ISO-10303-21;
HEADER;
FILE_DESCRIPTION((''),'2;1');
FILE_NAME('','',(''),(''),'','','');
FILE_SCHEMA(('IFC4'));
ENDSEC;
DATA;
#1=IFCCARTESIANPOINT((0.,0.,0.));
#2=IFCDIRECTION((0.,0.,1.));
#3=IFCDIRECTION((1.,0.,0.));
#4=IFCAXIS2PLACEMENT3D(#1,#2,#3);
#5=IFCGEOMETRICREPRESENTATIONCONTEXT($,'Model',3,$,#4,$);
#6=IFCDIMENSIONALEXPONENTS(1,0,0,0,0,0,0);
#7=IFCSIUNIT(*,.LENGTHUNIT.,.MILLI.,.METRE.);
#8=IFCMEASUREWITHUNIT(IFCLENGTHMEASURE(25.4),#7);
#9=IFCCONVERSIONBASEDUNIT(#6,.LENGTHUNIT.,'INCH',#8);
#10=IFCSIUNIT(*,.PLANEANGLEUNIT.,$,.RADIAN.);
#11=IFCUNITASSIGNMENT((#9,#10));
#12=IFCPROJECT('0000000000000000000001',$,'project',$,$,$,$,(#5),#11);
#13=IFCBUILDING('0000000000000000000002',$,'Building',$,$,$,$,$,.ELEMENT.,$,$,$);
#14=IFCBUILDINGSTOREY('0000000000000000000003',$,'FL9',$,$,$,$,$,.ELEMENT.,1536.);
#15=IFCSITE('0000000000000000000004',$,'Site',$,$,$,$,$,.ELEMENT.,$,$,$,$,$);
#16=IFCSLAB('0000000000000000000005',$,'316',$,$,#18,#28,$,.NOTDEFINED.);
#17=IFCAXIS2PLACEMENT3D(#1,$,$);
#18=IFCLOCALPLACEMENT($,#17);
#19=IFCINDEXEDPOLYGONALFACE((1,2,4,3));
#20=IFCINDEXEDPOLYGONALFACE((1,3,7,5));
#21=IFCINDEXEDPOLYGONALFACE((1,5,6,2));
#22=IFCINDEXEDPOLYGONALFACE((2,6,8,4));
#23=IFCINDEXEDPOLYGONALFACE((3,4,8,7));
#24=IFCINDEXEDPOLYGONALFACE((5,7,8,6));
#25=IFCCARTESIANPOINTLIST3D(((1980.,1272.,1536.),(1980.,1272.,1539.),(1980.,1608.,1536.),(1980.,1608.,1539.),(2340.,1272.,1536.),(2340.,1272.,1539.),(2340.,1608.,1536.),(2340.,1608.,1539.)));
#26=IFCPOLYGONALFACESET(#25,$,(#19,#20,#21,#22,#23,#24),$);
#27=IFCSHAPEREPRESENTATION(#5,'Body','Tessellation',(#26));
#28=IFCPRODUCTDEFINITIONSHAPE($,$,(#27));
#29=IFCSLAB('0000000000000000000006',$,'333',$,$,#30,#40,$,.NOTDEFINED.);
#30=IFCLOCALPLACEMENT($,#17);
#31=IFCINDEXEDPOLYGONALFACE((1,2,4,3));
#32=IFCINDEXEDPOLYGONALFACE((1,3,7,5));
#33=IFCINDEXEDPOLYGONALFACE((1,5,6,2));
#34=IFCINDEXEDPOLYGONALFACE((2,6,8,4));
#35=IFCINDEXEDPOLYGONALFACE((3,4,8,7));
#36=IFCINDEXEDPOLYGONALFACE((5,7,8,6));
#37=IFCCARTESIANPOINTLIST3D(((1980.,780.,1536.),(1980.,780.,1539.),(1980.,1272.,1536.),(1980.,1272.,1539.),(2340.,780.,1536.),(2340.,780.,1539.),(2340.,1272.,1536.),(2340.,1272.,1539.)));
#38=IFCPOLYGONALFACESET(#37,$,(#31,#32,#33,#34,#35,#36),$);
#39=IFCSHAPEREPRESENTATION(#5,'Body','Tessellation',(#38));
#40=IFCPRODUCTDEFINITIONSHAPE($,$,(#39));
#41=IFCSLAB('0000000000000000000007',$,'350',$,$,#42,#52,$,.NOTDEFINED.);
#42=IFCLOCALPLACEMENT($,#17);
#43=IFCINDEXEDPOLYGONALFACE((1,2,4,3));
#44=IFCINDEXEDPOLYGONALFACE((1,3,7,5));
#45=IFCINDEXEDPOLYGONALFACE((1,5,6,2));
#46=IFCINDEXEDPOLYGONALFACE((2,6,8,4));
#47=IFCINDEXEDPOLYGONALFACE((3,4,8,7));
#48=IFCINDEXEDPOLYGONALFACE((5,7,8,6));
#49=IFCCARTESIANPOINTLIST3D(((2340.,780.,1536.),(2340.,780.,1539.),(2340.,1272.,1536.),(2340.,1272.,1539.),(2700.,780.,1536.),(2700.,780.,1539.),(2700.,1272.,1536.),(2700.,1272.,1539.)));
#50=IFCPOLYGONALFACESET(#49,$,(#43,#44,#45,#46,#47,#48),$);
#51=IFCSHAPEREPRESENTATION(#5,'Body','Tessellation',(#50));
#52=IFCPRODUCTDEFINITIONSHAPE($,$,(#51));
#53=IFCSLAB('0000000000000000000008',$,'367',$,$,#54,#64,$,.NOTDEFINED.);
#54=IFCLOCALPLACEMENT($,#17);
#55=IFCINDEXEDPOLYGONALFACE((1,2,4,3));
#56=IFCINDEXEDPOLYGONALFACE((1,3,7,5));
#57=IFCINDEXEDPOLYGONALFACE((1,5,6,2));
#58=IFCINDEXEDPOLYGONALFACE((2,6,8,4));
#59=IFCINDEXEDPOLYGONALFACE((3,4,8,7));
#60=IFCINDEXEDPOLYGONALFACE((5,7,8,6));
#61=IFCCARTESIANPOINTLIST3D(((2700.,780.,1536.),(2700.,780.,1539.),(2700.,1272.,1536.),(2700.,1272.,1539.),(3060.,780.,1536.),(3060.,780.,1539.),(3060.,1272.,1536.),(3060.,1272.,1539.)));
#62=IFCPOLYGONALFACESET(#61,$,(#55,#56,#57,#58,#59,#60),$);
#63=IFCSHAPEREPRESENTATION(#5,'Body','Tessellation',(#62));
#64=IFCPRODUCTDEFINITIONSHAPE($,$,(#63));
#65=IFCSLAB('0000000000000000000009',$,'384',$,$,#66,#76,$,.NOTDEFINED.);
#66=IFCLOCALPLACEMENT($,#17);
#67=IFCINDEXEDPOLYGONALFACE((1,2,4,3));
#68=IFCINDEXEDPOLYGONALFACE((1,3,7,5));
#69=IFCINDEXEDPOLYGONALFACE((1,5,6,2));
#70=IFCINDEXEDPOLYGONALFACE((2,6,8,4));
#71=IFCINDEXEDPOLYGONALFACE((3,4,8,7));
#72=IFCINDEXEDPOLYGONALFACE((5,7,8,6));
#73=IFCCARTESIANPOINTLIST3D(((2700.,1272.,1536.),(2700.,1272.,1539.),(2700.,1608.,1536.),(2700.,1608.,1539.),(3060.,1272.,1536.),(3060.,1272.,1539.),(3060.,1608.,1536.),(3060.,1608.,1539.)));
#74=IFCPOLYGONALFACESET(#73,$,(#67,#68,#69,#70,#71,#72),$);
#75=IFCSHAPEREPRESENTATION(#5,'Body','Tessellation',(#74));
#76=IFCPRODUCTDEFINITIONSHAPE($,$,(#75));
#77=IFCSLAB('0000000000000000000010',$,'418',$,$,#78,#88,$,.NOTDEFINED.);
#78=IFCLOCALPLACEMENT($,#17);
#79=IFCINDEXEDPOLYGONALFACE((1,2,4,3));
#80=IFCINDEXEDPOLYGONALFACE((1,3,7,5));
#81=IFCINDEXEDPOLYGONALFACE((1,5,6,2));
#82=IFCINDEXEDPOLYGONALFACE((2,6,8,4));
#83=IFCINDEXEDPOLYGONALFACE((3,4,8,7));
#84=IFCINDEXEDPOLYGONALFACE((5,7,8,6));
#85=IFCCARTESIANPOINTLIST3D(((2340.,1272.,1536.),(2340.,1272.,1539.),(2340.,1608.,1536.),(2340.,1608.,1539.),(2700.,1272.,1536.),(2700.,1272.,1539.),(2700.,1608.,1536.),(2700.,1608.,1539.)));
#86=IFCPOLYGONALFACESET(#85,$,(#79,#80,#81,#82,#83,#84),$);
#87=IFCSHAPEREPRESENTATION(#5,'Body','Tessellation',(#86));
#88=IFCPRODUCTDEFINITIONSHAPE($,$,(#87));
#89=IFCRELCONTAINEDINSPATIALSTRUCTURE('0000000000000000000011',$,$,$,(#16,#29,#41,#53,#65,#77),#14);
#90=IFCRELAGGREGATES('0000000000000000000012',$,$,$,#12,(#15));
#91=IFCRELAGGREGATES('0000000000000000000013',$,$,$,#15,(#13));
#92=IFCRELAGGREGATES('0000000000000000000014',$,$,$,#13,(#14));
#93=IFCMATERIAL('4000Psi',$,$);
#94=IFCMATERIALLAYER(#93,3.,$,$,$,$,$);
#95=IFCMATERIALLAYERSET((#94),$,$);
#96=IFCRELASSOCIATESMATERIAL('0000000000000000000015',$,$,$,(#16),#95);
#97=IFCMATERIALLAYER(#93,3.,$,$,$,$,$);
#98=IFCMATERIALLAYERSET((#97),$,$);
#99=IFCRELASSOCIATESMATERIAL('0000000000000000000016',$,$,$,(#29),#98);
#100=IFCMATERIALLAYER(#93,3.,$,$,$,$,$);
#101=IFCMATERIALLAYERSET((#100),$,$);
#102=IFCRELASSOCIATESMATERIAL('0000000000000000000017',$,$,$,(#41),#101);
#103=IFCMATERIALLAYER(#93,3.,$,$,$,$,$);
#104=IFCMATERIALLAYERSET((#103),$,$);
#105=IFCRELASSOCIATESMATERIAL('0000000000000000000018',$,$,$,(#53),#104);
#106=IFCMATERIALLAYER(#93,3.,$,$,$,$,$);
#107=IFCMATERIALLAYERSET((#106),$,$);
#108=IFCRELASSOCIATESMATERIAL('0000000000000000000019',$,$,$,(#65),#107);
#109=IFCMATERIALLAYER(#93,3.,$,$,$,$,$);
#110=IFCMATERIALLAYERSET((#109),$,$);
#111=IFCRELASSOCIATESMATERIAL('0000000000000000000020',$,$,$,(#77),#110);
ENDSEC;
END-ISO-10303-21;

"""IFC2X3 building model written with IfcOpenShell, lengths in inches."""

from ifc_helpers import new_model, entity, si_unit, converted_unit, frame, origin_with_axes, place, context, project, spatial, polyline, outline, extrude, material, layer, layer_set, layer_usage, element, save


model = new_model("IFC2X3")

# Units and contexts
model_context = context("Model", 3, world=origin_with_axes())
ifc_project = project(units=[converted_unit("LENGTHUNIT", "INCH", entity("IfcLengthMeasure", 25.4), si_unit("LENGTHUNIT", "METRE", prefix="MILLI"), dimensions=[1, 0, 0, 0, 0, 0, 0]), si_unit("PLANEANGLEUNIT", "RADIAN")], contexts=[model_context])

# Site, building, storey
site = spatial("IfcSite", under=ifc_project, Name="Site", CompositionType="ELEMENT")
building = spatial("IfcBuilding", under=site, Name="Building", CompositionType="ELEMENT")
storey = spatial("IfcBuildingStorey", under=building, Name="FL9", CompositionType="ELEMENT", Elevation=1536.0)

# Slabs
ifc_material_1 = material(Name="4000Psi")
ifc_layer_1 = layer(ifc_material_1, 3.0)
ifc_layer_set_1 = layer_set([ifc_layer_1])
ifc_layer_usage_1 = layer_usage(ifc_layer_set_1, "AXIS2", "POSITIVE", -3.0)
slab_1_placement = place(None, frame((1980.0, 1272.0, 1536.0), z_axis=(0.0, 0.0, 1.0), x_axis=(1.0, 0.0, 0.0)))
element("IfcSlab", 1, at=slab_1_placement, inside=storey, material=ifc_layer_usage_1, Name="316", PredefinedType="NOTDEFINED", context=model_context, shape_type="SweptSolid", body=[
    extrude(outline(polyline([(0.0, 0.0), (360.0, 0.0), (360.0, 336.0), (0.0, 336.0), (0.0, 0.0)])), origin_with_axes(), (0.0, 0.0, 1.0), 3.0),
])
ifc_layer_2 = layer(ifc_material_1, 3.0)
ifc_layer_set_2 = layer_set([ifc_layer_2])
ifc_layer_usage_2 = layer_usage(ifc_layer_set_2, "AXIS2", "POSITIVE", -3.0)
slab_2_placement = place(None, frame((1980.0, 780.0, 1536.0), z_axis=(0.0, 0.0, 1.0), x_axis=(1.0, 0.0, 0.0)))
element("IfcSlab", 2, at=slab_2_placement, inside=storey, material=ifc_layer_usage_2, Name="333", PredefinedType="NOTDEFINED", context=model_context, shape_type="SweptSolid", body=[
    extrude(outline(polyline([(0.0, 0.0), (360.0, 0.0), (360.0, 492.0), (0.0, 492.0), (0.0, 0.0)])), origin_with_axes(), (0.0, 0.0, 1.0), 3.0),
])
ifc_layer_3 = layer(ifc_material_1, 3.0)
ifc_layer_set_3 = layer_set([ifc_layer_3])
ifc_layer_usage_3 = layer_usage(ifc_layer_set_3, "AXIS2", "POSITIVE", -3.0)
slab_3_placement = place(None, frame((2340.0, 780.0, 1536.0), z_axis=(0.0, 0.0, 1.0), x_axis=(1.0, 0.0, 0.0)))
element("IfcSlab", 3, at=slab_3_placement, inside=storey, material=ifc_layer_usage_3, Name="350", PredefinedType="NOTDEFINED", context=model_context, shape_type="SweptSolid", body=[
    extrude(outline(polyline([(0.0, 0.0), (360.0, 0.0), (360.0, 492.0), (0.0, 492.0), (0.0, 0.0)])), origin_with_axes(), (0.0, 0.0, 1.0), 3.0),
])
ifc_layer_4 = layer(ifc_material_1, 3.0)
ifc_layer_set_4 = layer_set([ifc_layer_4])
ifc_layer_usage_4 = layer_usage(ifc_layer_set_4, "AXIS2", "POSITIVE", -3.0)
slab_4_placement = place(None, frame((2700.0, 780.0, 1536.0), z_axis=(0.0, 0.0, 1.0), x_axis=(1.0, 0.0, 0.0)))
element("IfcSlab", 4, at=slab_4_placement, inside=storey, material=ifc_layer_usage_4, Name="367", PredefinedType="NOTDEFINED", context=model_context, shape_type="SweptSolid", body=[
    extrude(outline(polyline([(0.0, 0.0), (360.0, 0.0), (360.0, 492.0), (0.0, 492.0), (0.0, 0.0)])), origin_with_axes(), (0.0, 0.0, 1.0), 3.0),
])
ifc_layer_5 = layer(ifc_material_1, 3.0)
ifc_layer_set_5 = layer_set([ifc_layer_5])
ifc_layer_usage_5 = layer_usage(ifc_layer_set_5, "AXIS2", "POSITIVE", -3.0)
slab_5_placement = place(None, frame((2700.0, 1272.0, 1536.0), z_axis=(0.0, 0.0, 1.0), x_axis=(1.0, 0.0, 0.0)))
element("IfcSlab", 5, at=slab_5_placement, inside=storey, material=ifc_layer_usage_5, Name="384", PredefinedType="NOTDEFINED", context=model_context, shape_type="SweptSolid", body=[
    extrude(outline(polyline([(0.0, 0.0), (360.0, 0.0), (360.0, 336.0), (0.0, 336.0), (0.0, 0.0)])), origin_with_axes(), (0.0, 0.0, 1.0), 3.0),
])
ifc_layer_6 = layer(ifc_material_1, 3.0)
ifc_layer_set_6 = layer_set([ifc_layer_6])
ifc_layer_usage_6 = layer_usage(ifc_layer_set_6, "AXIS2", "POSITIVE", -3.0)
slab_6_placement = place(None, frame((2340.0, 1272.0, 1536.0), z_axis=(0.0, 0.0, 1.0), x_axis=(1.0, 0.0, 0.0)))
element("IfcSlab", 6, at=slab_6_placement, inside=storey, material=ifc_layer_usage_6, Name="418", PredefinedType="NOTDEFINED", context=model_context, shape_type="SweptSolid", body=[
    extrude(outline(polyline([(0.0, 0.0), (360.0, 0.0), (360.0, 336.0), (0.0, 336.0), (0.0, 0.0)])), origin_with_axes(), (0.0, 0.0, 1.0), 3.0),
])

save(model, "model.ifc")
